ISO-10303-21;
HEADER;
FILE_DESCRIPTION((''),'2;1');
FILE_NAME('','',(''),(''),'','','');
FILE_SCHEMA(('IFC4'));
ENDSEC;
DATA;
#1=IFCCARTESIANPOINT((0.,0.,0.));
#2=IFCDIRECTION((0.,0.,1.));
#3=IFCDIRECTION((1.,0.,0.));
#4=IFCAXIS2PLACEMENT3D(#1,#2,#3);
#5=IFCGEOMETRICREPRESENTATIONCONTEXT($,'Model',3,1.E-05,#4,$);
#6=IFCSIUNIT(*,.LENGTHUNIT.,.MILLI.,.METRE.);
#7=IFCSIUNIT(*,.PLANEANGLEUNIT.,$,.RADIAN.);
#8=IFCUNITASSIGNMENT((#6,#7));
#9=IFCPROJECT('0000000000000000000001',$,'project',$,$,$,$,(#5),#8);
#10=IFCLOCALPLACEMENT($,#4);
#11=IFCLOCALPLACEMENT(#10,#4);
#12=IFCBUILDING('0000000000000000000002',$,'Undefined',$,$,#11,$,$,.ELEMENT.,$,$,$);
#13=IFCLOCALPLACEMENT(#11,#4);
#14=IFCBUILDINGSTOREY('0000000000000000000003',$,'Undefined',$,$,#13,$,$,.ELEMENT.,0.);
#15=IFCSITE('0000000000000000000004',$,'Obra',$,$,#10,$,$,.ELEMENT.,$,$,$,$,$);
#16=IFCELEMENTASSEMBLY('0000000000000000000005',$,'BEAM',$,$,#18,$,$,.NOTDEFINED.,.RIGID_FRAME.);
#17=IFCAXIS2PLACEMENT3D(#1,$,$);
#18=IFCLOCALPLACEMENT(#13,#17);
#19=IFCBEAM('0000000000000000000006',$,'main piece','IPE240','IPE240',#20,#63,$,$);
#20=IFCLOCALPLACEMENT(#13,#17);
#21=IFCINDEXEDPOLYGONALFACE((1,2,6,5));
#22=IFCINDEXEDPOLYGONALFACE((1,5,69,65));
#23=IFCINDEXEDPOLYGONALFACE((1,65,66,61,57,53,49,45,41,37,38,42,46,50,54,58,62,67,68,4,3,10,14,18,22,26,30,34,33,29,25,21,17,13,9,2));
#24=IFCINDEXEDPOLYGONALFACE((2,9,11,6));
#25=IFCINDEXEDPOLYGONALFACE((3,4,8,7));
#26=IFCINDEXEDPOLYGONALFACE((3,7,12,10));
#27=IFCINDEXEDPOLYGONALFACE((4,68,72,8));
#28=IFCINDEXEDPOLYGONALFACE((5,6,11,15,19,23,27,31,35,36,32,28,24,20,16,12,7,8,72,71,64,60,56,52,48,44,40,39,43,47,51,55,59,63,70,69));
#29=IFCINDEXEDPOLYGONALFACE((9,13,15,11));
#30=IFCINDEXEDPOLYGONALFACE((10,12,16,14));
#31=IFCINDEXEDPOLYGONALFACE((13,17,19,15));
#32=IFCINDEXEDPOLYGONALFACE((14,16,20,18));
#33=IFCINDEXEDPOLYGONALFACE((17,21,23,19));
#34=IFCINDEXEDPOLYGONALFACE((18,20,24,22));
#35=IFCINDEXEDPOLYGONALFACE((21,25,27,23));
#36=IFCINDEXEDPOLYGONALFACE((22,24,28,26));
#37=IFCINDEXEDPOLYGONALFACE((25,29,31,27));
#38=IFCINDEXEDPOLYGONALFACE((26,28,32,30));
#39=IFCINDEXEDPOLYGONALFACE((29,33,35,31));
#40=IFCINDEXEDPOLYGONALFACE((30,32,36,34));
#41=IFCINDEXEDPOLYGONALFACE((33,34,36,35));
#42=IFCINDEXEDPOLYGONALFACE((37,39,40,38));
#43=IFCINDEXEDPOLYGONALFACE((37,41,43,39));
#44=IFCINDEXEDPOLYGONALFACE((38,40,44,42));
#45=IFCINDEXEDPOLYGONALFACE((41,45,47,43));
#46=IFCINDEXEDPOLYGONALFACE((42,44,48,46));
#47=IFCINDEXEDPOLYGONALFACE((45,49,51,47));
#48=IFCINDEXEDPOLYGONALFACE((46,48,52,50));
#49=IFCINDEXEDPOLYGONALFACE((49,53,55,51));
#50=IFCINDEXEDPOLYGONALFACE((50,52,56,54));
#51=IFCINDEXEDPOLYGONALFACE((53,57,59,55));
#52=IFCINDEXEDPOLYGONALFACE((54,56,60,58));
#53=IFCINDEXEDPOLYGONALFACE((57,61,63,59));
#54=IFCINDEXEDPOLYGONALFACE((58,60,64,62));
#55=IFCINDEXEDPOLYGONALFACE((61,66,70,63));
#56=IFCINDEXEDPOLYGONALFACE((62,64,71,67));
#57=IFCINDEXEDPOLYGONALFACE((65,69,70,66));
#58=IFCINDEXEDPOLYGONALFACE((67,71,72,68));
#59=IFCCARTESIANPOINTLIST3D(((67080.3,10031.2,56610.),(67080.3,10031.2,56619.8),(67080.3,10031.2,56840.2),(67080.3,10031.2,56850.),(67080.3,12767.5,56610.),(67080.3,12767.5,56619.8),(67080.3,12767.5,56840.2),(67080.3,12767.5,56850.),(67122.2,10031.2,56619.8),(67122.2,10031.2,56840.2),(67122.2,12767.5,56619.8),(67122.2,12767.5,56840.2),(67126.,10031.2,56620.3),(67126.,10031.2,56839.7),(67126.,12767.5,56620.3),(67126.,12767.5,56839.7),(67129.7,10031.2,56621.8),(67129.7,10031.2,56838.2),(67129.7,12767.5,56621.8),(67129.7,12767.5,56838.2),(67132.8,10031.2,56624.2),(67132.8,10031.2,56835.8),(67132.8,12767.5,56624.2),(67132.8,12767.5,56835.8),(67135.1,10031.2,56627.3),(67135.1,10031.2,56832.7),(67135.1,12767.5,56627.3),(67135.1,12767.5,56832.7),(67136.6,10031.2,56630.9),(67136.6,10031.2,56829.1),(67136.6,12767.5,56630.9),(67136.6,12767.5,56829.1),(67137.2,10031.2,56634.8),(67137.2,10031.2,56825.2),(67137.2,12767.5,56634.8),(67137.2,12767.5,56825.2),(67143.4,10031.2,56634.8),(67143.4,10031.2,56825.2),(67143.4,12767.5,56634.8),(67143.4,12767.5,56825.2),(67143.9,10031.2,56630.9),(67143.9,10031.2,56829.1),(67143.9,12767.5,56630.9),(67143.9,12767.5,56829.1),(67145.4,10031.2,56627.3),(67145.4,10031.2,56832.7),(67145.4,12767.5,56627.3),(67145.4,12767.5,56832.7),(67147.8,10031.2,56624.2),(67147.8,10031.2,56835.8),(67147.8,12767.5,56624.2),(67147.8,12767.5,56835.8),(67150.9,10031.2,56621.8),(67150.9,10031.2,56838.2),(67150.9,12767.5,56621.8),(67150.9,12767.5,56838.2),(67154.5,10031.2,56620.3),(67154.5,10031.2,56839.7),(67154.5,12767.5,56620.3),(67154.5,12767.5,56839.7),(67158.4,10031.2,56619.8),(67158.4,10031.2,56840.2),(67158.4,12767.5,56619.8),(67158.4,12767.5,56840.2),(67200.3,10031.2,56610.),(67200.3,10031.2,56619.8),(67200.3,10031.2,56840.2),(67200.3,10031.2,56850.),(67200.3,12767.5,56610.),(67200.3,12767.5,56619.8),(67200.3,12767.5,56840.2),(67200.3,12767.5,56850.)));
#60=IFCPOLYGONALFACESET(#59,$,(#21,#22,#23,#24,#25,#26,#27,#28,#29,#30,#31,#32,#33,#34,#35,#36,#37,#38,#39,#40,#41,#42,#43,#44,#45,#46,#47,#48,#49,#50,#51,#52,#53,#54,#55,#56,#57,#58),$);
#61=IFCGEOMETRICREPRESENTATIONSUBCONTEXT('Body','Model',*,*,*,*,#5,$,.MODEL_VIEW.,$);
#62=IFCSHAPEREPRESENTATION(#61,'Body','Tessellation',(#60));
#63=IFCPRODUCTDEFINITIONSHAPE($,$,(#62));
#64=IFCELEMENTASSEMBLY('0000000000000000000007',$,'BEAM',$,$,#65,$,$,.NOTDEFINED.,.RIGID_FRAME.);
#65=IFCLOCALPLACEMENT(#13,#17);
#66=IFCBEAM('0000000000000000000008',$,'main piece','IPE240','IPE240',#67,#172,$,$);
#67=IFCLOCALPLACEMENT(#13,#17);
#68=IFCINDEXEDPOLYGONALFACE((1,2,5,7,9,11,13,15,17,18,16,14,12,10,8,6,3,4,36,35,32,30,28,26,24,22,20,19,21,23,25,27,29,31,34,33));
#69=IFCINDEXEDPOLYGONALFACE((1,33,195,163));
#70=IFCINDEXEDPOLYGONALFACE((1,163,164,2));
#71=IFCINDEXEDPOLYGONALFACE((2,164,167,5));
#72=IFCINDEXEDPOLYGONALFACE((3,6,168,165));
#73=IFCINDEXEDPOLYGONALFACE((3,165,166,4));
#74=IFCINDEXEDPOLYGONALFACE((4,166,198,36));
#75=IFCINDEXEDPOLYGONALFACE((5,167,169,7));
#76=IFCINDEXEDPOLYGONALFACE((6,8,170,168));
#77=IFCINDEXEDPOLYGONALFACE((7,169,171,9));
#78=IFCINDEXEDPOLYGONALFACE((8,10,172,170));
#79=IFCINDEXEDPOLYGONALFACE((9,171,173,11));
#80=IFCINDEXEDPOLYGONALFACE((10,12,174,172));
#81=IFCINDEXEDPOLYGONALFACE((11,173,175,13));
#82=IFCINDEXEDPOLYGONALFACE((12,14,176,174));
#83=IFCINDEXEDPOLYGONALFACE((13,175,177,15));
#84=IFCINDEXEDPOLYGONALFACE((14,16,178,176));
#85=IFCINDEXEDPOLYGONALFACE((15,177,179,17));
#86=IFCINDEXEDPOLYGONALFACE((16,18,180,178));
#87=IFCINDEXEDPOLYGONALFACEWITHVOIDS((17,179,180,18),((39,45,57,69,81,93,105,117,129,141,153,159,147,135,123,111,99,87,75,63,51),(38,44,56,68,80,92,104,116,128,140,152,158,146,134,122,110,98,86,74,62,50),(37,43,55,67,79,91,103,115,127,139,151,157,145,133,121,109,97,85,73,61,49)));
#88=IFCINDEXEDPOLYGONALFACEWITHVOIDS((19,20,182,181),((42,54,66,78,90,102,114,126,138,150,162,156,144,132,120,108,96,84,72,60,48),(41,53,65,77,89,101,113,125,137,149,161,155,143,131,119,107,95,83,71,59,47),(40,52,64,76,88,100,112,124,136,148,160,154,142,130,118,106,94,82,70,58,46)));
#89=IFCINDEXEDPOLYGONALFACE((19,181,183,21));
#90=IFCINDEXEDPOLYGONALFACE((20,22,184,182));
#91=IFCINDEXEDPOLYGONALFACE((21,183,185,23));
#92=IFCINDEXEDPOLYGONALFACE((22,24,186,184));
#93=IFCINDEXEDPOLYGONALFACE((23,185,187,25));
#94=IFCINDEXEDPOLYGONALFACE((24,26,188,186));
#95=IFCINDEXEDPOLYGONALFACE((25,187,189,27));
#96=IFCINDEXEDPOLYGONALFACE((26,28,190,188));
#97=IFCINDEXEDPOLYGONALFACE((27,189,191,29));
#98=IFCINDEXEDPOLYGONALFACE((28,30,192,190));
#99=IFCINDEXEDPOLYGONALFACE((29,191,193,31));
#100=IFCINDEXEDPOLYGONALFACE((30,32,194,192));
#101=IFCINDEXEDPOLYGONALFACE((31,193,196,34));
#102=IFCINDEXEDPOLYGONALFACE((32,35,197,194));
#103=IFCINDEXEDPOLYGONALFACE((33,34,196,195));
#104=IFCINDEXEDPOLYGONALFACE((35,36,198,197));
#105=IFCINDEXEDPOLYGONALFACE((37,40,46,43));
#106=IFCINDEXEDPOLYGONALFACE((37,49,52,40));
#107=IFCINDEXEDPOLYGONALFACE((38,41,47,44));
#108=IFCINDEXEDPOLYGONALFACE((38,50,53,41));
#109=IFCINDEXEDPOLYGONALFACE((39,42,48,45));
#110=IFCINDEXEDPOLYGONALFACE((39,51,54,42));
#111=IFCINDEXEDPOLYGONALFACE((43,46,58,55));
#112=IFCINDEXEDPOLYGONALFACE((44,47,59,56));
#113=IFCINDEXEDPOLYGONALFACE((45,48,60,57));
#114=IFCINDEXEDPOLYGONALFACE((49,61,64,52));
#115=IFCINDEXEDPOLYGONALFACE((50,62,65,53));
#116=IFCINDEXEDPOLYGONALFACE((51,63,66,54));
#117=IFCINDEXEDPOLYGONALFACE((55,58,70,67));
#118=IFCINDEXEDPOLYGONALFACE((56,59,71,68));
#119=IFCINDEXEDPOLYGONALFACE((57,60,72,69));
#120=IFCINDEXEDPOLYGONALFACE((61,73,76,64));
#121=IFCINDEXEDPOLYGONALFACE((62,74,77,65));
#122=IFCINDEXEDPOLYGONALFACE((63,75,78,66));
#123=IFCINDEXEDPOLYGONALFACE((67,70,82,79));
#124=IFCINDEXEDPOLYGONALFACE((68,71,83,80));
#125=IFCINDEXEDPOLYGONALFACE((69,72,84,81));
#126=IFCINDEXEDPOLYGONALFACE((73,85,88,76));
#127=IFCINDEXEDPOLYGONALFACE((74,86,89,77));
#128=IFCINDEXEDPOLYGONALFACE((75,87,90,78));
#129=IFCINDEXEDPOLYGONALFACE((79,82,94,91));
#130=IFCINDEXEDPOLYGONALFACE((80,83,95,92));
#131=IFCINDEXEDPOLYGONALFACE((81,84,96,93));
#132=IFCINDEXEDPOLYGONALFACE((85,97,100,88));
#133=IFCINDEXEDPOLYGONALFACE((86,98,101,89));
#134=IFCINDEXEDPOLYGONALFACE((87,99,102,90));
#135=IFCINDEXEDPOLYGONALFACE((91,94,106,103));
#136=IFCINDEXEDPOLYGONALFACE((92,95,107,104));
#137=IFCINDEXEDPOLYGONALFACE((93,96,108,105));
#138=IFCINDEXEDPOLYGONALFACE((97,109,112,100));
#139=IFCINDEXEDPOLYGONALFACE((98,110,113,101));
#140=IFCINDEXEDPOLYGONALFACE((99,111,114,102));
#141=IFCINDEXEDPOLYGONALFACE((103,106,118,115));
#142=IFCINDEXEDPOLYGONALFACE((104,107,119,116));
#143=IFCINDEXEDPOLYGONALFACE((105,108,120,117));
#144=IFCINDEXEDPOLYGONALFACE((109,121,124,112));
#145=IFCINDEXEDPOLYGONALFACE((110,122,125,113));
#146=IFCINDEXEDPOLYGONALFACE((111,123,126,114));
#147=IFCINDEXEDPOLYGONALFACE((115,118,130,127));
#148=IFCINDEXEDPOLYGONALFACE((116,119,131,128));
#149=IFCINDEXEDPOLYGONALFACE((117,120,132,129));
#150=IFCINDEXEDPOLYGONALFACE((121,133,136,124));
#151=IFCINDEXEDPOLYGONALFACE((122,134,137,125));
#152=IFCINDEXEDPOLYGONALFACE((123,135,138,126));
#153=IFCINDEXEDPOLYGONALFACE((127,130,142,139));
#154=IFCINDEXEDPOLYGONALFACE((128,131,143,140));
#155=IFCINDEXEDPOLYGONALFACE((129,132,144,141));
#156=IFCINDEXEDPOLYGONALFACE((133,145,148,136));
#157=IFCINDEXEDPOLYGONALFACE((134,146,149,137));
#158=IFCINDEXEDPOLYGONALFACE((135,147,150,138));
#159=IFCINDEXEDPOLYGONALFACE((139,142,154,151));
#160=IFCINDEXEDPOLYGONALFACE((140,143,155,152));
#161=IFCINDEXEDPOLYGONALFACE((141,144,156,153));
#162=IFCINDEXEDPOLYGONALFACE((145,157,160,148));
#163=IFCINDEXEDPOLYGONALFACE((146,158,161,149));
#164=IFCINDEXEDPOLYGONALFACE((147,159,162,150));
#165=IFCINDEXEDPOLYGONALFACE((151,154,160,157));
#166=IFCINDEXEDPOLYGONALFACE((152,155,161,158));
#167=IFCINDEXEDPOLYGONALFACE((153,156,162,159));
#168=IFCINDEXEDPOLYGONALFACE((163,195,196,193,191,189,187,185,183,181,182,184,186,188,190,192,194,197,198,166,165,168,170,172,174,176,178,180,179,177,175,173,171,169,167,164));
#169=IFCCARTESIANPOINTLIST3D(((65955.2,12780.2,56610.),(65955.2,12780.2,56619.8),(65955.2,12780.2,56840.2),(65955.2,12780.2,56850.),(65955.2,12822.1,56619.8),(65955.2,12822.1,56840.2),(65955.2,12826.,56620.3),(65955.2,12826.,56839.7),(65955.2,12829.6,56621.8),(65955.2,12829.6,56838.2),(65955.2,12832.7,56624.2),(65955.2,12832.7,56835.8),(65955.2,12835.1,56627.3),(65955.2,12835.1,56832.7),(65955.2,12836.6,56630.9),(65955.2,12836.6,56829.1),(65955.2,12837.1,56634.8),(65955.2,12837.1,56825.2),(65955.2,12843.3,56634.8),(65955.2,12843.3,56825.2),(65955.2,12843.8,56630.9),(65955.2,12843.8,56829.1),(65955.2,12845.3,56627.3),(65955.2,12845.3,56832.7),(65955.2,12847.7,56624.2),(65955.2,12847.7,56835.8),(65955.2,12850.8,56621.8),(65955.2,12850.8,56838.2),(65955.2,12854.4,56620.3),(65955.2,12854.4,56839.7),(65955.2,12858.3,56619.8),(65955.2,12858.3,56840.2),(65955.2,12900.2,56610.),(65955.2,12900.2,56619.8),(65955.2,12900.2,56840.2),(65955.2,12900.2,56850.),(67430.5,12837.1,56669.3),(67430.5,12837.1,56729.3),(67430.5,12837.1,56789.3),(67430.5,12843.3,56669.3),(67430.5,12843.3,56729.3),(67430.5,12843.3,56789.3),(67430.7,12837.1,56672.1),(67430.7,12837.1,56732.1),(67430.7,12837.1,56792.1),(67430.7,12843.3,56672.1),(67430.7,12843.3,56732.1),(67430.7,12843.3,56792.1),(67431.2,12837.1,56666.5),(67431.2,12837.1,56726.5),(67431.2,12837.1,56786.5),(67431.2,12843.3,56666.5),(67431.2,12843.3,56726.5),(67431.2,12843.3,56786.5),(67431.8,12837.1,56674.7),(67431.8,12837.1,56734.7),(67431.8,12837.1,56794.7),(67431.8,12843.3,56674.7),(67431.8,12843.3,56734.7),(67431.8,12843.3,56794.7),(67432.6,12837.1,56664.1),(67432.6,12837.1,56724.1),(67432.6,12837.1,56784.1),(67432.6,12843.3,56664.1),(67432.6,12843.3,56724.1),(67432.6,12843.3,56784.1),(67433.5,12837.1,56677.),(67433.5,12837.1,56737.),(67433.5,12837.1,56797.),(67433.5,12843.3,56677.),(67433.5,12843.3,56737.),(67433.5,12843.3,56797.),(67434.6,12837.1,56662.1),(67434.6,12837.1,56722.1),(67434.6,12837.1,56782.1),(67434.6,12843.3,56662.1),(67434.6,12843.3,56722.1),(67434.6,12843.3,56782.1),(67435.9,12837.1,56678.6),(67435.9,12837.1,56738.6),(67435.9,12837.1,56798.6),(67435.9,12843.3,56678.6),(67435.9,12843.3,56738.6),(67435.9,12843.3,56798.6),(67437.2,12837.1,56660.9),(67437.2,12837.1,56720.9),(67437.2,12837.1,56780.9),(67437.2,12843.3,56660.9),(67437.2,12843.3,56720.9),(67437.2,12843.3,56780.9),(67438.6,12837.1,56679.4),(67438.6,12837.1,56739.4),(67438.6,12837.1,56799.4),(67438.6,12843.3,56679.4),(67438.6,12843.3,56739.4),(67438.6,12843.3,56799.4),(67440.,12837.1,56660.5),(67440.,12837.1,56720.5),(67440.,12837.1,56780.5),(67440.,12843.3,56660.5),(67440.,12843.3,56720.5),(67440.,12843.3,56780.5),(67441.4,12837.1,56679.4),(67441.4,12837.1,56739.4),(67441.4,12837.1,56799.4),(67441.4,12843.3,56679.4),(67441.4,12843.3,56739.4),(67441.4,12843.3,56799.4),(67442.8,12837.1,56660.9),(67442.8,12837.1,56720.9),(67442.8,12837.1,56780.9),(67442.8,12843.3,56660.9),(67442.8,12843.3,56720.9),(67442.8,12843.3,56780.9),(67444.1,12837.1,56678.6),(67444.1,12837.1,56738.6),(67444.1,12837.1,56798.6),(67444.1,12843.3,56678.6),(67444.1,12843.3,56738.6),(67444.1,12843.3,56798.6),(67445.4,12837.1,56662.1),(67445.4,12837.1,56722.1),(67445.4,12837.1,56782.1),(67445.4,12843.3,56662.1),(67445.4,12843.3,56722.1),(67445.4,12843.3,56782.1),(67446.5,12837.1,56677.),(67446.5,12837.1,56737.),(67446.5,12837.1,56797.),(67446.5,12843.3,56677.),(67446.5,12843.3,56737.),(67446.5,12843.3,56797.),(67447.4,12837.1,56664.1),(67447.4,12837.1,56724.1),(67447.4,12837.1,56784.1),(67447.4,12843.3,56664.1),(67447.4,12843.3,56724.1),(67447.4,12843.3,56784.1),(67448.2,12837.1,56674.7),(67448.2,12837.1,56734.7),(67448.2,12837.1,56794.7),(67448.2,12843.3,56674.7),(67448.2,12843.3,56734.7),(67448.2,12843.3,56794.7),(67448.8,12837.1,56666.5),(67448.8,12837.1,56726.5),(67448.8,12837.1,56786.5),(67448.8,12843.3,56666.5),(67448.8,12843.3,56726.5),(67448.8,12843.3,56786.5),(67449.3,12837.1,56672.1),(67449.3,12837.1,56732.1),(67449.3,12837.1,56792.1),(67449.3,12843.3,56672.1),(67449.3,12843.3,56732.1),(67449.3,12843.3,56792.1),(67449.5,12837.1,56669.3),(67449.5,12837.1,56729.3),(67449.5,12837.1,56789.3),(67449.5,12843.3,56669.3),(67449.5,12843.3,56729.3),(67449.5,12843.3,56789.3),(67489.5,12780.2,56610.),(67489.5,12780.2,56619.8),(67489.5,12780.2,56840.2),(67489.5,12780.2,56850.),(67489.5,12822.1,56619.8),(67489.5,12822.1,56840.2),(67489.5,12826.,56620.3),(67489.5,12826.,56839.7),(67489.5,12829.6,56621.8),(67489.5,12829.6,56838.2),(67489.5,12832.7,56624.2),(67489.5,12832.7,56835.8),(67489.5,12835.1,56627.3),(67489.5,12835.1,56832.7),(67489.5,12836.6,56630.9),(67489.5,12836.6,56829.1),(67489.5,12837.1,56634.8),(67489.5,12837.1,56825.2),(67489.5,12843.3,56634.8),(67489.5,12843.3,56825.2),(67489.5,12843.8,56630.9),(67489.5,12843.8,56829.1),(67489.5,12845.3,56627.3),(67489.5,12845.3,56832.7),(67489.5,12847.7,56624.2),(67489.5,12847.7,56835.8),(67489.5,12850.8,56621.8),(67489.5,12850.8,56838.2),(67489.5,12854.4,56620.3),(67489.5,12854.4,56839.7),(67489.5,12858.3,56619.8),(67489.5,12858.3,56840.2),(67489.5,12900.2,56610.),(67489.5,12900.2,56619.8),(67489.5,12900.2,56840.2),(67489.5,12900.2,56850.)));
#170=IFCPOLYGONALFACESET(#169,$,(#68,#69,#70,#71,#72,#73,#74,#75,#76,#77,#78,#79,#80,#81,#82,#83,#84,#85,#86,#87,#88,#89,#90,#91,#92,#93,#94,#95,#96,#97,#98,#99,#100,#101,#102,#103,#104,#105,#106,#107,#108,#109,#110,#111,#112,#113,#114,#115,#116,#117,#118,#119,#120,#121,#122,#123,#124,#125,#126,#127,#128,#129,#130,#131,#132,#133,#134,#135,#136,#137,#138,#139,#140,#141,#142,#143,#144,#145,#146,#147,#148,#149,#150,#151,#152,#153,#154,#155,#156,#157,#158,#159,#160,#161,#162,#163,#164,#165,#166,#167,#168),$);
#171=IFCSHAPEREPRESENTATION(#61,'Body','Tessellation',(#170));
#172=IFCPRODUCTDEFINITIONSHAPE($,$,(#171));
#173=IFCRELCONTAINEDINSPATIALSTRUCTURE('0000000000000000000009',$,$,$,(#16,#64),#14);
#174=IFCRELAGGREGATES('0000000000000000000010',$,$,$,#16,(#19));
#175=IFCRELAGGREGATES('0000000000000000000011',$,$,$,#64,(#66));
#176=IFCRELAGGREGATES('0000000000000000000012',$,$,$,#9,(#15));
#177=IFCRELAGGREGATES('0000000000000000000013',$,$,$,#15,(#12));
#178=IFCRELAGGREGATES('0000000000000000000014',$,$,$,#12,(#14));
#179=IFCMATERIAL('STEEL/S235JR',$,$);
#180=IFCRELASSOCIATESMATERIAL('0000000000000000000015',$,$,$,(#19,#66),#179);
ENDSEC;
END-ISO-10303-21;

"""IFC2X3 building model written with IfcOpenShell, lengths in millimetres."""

from ifc_helpers import new_model, si_unit, frame, origin_with_axes, origin_2d_with_axis, place, context, subcontext, project, spatial, circle, i_section, extrude, clip, halfspace, source, transform, mapped, material, element, aggregate, save


model = new_model("IFC2X3")

# Units and contexts
model_context = context("Model", 3, precision=1e-05, world=origin_with_axes())
body_context = subcontext(model_context, "Body", "Model", "MODEL_VIEW")
ifc_project = project(units=[si_unit("LENGTHUNIT", "METRE", prefix="MILLI"), si_unit("PLANEANGLEUNIT", "RADIAN")], contexts=[model_context])

# Site, building, storey
site_placement = place(None, origin_with_axes())
site = spatial("IfcSite", under=ifc_project, at=site_placement, Name="Obra", CompositionType="ELEMENT")
building_placement = place(site_placement, origin_with_axes())
building = spatial("IfcBuilding", under=site, at=building_placement, Name="Undefined", CompositionType="ELEMENT")
storey_placement = place(building_placement, origin_with_axes())
storey = spatial("IfcBuildingStorey", under=building, at=storey_placement, Name="Undefined", CompositionType="ELEMENT", Elevation=0.0)

# Shared definitions
ifc_material_1 = material(Name="STEEL/S235JR")

# Element assembly, beam
assembly_1_placement = place(storey_placement, origin_with_axes())
assembly_1 = element("IfcElementAssembly", 1, at=assembly_1_placement, inside=storey, Name="BEAM", AssemblyPlace="NOTDEFINED", PredefinedType="RIGID_FRAME")
beam_1_placement = place(assembly_1_placement, frame((67140.3, 10031.2, 56730.0), z_axis=(0.0, 0.0, 1.0), x_axis=(0.0, 1.0, 0.0)))
beam_1 = element("IfcBeam", 2, at=beam_1_placement, material=ifc_material_1, Name="main piece", Description="IPE240", ObjectType="IPE240", context=body_context, shape_type="SweptSolid", body=[
    extrude(i_section(OverallWidth=120.0, OverallDepth=240.0, WebThickness=6.2, FlangeThickness=9.8, FilletRadius=15.0, at=origin_2d_with_axis()), frame((2736.3, 0.0, 0.0), z_axis=(-1.0, 0.0, 0.0), x_axis=(0.0, -1.0, 0.0)), (0.0, 0.0, 1.0), 2736.3),
])
aggregate(assembly_1, [beam_1])

# Element assembly, beam, opening
assembly_2_placement = place(storey_placement, origin_with_axes())
assembly_2 = element("IfcElementAssembly", 3, at=assembly_2_placement, inside=storey, Name="BEAM", AssemblyPlace="NOTDEFINED", PredefinedType="RIGID_FRAME")
beam_2_placement = place(assembly_2_placement, frame((65955.2, 12840.2, 56730.0), z_axis=(0.0, 0.0, 1.0), x_axis=(1.0, 0.000002, 0.0)))
beam_2 = element("IfcBeam", 4, at=beam_2_placement, material=ifc_material_1, Name="main piece", Description="IPE240", ObjectType="IPE240", context=body_context, shape_type="Clipping", body=[
    clip(extrude(i_section(OverallWidth=120.0, OverallDepth=240.0, WebThickness=6.2, FlangeThickness=9.8, FilletRadius=15.0, at=origin_2d_with_axis()), frame((1842.9, 0.0, 0.0), z_axis=(-1.0, 0.0, 0.0), x_axis=(0.0, -1.0, 0.0)), (0.0, 0.0, 1.0), 1842.9), halfspace(frame((1534.3, -60.0, -120.0), z_axis=(1.0, 0.000017, 0.0), x_axis=(0.0, 0.0, 1.0)), False)),
])
shared_shape_1 = source(origin_with_axes(), body_context, "Body", "SweptSolid", [
    extrude(circle(Radius=9.5, at=origin_2d_with_axis()), frame((0.0, -3.2, 0.0), z_axis=(0.0, 1.0, 0.0), x_axis=(1.0, 0.0, 0.0)), (0.0, 0.0, 1.0), 6.4),
])
opening_1_placement = place(assembly_2_placement, frame((67490.0, 12840.2, 56850.0), z_axis=(-1.0, 0.0, 0.0), x_axis=(0.0, 0.0, -1.0)))
element("IfcOpeningElement", 5, at=opening_1_placement, cuts=beam_2, ObjectType="Opening", context=body_context, shape_type="MappedRepresentation", body=[
    mapped(shared_shape_1, transform((60.0, 0.0, 50.0))),
    mapped(shared_shape_1, transform((120.0, 0.0, 50.0))),
    mapped(shared_shape_1, transform((180.0, 0.0, 50.0))),
])
aggregate(assembly_2, [beam_2])

save(model, "model.ifc")
